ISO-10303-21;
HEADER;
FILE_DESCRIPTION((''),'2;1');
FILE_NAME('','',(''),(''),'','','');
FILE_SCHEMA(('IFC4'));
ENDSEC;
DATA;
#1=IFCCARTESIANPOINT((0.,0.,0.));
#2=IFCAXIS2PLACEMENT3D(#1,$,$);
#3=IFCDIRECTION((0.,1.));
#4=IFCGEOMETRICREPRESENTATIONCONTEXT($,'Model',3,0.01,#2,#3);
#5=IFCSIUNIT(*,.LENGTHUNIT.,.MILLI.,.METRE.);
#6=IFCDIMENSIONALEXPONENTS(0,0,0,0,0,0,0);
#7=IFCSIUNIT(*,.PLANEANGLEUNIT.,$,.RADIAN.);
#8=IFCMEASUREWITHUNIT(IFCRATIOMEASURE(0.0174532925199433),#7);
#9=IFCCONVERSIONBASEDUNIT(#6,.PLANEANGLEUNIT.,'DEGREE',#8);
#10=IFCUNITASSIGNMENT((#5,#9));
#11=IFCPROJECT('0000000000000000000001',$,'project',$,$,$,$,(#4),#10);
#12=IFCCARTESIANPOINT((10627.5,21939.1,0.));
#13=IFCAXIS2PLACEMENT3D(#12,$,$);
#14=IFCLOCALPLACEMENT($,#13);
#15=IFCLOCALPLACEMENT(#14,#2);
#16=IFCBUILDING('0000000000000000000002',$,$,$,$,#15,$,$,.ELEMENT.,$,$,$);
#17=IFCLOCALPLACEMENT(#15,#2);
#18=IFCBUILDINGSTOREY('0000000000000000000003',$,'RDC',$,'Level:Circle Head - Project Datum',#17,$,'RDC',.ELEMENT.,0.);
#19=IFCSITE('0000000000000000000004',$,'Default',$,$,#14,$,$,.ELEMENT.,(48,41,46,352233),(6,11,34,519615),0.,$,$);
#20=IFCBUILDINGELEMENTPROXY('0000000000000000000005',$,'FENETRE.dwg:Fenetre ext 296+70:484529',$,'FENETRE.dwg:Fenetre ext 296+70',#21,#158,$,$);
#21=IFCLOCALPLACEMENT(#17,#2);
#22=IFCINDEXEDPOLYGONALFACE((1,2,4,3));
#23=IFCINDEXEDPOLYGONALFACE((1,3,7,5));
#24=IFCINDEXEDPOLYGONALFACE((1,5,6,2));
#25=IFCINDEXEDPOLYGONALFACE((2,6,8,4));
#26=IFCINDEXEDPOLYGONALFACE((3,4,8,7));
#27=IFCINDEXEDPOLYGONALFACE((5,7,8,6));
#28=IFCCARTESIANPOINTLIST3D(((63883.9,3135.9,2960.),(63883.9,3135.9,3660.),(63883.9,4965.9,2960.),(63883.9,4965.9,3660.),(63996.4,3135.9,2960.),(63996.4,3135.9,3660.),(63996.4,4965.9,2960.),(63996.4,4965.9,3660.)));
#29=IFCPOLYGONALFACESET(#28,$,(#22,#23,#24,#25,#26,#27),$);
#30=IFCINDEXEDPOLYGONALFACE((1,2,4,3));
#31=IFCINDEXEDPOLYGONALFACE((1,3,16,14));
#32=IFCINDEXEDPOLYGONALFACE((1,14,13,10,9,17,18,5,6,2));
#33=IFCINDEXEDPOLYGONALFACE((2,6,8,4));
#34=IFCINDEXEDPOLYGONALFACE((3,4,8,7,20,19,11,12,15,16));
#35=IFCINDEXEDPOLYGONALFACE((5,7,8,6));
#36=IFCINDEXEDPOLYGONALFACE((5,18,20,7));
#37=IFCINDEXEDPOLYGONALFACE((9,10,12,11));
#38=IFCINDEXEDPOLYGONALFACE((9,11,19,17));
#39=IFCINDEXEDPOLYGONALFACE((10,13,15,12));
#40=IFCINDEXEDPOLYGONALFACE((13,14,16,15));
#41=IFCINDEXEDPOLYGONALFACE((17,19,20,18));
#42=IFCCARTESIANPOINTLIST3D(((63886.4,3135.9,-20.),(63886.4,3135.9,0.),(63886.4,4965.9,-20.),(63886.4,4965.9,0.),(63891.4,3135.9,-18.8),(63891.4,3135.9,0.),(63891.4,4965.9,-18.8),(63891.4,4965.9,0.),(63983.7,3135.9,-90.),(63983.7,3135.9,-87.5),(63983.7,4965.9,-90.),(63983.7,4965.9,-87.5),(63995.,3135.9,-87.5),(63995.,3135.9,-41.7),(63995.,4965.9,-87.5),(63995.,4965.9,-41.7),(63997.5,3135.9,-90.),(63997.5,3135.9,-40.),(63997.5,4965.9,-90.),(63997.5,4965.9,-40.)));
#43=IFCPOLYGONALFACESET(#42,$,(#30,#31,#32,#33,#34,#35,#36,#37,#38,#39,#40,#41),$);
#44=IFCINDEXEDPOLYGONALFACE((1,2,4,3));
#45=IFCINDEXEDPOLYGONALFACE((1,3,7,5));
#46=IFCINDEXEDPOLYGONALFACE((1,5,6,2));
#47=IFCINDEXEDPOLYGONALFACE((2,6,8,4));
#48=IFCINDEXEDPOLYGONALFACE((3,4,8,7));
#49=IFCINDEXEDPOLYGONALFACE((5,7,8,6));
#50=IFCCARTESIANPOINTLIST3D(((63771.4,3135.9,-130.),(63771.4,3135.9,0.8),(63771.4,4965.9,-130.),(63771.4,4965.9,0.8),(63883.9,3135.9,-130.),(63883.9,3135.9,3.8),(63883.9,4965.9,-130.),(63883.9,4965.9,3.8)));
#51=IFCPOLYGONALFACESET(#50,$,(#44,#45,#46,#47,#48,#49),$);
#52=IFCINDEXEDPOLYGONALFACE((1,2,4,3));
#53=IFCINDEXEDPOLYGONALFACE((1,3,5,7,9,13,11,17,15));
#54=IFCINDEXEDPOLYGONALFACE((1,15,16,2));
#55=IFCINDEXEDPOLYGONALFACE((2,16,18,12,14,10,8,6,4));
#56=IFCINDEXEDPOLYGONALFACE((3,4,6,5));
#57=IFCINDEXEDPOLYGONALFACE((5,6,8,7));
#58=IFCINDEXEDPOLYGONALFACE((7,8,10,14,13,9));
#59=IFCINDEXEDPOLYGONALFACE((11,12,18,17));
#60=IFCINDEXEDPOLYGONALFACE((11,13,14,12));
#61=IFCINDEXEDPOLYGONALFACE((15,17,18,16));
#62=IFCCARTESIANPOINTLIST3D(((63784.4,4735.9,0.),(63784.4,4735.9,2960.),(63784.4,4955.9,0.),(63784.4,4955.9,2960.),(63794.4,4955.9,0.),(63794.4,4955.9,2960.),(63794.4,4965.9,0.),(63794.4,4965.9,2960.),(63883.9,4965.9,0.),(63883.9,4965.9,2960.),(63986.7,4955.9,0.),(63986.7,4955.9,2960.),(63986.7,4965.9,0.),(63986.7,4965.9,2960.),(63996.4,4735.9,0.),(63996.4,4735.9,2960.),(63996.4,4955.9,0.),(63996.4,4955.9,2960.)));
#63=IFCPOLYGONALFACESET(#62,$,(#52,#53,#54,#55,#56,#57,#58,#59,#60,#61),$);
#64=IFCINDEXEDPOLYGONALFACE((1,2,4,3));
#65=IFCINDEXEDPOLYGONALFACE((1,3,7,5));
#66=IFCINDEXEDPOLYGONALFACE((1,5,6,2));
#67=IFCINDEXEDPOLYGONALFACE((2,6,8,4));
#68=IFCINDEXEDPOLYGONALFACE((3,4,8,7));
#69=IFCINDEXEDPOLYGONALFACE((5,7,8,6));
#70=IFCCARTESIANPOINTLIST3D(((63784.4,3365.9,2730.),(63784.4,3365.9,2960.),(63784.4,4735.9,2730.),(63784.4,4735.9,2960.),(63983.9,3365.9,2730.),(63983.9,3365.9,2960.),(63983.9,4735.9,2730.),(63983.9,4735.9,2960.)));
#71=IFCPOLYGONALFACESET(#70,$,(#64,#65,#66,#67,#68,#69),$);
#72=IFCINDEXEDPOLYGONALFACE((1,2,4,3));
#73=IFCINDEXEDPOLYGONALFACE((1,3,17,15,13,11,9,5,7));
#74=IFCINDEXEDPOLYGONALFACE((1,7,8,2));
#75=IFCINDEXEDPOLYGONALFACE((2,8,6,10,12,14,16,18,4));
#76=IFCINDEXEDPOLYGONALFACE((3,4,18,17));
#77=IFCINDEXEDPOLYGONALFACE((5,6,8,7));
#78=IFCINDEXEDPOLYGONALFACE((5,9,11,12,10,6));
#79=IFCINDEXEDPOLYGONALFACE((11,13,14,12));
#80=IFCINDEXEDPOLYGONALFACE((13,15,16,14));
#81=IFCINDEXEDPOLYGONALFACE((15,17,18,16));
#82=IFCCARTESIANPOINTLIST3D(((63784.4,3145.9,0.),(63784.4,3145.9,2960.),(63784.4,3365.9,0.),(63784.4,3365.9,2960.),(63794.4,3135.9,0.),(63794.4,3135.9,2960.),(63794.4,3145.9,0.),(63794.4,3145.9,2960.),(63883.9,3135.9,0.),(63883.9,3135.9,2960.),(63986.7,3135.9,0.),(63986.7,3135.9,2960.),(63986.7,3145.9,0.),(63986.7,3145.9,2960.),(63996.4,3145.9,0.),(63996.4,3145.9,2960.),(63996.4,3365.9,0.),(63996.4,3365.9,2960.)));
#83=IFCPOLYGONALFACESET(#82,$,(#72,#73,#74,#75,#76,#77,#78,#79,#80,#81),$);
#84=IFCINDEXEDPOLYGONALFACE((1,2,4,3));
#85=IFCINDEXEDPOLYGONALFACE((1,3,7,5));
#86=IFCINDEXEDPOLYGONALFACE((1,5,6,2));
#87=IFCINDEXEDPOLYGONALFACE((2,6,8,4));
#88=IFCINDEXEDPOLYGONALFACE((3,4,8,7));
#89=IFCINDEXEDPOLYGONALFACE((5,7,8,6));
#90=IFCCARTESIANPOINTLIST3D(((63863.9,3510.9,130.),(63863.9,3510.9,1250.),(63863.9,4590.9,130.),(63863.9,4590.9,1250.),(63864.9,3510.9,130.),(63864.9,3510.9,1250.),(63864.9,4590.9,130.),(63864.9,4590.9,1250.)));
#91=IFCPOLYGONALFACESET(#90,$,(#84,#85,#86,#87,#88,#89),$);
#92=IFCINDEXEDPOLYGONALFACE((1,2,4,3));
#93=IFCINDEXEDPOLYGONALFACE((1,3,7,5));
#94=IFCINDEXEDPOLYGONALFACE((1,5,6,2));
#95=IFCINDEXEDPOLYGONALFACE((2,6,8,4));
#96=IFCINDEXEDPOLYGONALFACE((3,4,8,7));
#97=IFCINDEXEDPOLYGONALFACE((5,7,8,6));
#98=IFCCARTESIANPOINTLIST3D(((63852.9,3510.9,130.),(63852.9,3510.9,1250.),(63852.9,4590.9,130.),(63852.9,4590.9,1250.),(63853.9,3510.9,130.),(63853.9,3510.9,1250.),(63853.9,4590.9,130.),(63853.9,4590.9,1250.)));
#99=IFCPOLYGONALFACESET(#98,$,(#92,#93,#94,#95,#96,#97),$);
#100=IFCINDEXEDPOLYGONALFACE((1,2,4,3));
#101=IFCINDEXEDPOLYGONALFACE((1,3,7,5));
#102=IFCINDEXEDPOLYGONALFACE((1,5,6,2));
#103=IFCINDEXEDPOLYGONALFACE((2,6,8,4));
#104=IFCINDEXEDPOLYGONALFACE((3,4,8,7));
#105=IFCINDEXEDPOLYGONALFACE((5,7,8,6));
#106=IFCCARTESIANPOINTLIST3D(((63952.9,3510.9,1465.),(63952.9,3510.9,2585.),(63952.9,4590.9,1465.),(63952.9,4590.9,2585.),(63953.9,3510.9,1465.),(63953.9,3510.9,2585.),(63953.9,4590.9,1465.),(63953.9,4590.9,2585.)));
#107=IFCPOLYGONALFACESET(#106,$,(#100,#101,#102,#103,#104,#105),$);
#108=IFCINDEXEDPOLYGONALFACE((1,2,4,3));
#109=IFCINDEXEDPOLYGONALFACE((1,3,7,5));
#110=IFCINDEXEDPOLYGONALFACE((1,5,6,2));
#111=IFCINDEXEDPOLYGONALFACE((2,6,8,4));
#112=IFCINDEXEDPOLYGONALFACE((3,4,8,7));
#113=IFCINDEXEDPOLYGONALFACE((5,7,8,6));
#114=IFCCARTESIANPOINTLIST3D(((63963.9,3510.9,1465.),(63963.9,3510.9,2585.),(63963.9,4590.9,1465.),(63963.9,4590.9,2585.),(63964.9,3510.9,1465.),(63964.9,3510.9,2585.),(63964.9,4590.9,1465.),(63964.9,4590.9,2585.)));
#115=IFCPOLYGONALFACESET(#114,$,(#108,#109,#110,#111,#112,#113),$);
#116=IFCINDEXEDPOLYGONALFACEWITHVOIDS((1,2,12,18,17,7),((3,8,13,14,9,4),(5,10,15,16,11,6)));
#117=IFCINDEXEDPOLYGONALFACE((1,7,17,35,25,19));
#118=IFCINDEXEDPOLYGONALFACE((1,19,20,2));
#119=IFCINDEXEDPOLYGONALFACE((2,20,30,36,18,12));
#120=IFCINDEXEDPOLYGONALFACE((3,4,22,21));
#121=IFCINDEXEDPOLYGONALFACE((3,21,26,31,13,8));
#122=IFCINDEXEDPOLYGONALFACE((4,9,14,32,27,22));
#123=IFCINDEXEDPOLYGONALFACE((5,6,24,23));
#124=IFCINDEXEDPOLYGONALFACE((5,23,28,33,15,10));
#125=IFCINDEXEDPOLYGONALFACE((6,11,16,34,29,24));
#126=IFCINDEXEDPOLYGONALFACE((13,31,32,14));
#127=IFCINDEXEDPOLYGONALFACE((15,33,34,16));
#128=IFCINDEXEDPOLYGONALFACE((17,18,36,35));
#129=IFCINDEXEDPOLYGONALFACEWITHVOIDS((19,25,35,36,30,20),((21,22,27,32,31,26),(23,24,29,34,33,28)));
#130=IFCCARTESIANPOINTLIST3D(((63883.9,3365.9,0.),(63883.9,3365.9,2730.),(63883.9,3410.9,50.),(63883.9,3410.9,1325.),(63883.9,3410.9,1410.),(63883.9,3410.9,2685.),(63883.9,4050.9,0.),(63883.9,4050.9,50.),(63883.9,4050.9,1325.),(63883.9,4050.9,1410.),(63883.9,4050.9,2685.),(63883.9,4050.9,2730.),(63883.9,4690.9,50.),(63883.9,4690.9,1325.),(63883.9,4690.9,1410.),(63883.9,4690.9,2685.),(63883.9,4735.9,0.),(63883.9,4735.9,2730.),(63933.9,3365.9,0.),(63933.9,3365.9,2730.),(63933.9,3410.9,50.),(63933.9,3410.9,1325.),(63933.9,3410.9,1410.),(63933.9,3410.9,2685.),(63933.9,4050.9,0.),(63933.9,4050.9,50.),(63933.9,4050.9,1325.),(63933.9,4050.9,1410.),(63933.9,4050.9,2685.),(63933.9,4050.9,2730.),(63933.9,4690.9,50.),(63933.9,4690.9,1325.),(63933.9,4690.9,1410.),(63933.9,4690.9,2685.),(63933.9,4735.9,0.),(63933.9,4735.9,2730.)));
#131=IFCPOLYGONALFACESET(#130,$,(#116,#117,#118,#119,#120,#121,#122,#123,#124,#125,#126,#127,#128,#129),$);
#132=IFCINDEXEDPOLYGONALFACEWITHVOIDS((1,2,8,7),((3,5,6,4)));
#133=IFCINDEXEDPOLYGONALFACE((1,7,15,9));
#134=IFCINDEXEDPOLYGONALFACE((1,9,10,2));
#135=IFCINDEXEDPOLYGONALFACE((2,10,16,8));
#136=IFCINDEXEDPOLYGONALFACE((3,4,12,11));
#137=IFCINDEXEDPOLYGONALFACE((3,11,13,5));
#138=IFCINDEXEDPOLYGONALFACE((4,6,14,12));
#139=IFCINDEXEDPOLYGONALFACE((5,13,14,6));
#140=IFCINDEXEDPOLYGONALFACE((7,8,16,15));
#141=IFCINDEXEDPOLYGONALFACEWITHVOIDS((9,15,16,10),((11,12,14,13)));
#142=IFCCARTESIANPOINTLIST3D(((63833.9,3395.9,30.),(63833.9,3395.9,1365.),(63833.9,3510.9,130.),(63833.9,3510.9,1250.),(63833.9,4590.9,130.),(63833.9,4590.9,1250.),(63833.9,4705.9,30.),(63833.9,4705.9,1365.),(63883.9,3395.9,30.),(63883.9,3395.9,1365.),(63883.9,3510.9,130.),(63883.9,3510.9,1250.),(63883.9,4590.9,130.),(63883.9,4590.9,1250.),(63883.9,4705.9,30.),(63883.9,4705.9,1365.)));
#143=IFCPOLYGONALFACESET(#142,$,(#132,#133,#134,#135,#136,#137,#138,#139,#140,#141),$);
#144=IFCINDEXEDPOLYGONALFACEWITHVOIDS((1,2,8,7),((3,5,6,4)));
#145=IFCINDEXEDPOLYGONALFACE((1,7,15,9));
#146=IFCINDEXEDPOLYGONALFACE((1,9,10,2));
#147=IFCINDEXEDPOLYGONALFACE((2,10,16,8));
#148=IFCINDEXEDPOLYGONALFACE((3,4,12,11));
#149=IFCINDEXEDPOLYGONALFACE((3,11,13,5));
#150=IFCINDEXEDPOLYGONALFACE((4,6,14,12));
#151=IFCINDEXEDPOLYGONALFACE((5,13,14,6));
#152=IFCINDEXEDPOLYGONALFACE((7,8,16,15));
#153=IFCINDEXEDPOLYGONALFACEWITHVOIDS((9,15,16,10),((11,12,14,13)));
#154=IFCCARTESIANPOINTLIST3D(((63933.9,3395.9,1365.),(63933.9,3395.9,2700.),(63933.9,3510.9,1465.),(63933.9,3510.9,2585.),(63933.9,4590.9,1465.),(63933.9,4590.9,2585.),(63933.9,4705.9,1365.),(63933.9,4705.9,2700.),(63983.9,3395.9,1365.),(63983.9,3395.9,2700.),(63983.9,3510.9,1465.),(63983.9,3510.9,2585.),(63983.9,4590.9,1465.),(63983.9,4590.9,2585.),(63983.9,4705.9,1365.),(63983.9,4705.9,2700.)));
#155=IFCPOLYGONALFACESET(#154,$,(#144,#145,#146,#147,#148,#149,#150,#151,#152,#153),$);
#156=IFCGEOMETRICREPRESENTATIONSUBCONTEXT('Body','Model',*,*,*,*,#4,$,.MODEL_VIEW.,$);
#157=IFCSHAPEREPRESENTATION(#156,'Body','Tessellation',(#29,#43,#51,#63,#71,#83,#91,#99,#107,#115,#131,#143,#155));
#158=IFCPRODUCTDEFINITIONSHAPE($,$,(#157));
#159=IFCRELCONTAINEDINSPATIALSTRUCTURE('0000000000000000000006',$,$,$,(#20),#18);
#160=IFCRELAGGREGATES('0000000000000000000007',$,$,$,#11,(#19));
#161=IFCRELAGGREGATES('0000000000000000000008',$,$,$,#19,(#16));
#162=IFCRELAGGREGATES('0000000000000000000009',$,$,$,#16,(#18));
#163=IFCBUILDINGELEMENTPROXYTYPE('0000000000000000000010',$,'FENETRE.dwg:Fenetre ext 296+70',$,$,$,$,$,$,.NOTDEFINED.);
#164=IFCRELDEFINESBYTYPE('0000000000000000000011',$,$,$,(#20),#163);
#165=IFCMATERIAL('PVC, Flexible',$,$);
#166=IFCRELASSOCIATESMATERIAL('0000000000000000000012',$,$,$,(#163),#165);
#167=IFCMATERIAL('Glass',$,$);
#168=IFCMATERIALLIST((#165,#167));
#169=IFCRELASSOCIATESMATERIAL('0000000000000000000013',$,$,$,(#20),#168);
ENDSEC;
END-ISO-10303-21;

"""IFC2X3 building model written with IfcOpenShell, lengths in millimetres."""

from ifc_helpers import new_model, entity, si_unit, converted_unit, direction, frame, frame_2d, origin, origin_2d_with_axis, place, context, subcontext, project, spatial, polyline, rectangle, outline, extrude, source, transform, mapped, material, material_list, type_object, type_shapes, element, save


model = new_model("IFC2X3")

# Units and contexts
model_context = context("Model", 3, precision=0.01, world=origin(), true_north=direction((0.0, 1.0)))
body_context = subcontext(model_context, "Body", "Model", "MODEL_VIEW")
ifc_project = project(units=[si_unit("LENGTHUNIT", "METRE", prefix="MILLI"), converted_unit("PLANEANGLEUNIT", "DEGREE", entity("IfcRatioMeasure", 0.0174532925199433), si_unit("PLANEANGLEUNIT", "RADIAN"), dimensions=[0, 0, 0, 0, 0, 0, 0])], contexts=[model_context])

# Site, building, storey
site_placement = place(None, frame((10627.5, 21939.1, 0.0)))
site = spatial("IfcSite", under=ifc_project, at=site_placement, Name="Default", CompositionType="ELEMENT", RefLatitude=(48, 41, 46, 352233), RefLongitude=(6, 11, 34, 519615), RefElevation=0.0)
building_placement = place(site_placement, origin())
building = spatial("IfcBuilding", under=site, at=building_placement, CompositionType="ELEMENT")
storey_placement = place(building_placement, origin())
storey = spatial("IfcBuildingStorey", under=building, at=storey_placement, Name="RDC", ObjectType="Level:Circle Head - Project Datum", LongName="RDC", CompositionType="ELEMENT", Elevation=0.0)

# Building element proxy
ifc_material_1 = material(Name="PVC, Flexible")
ifc_material_2 = material(Name="Glass")
building_element_proxy_type_1 = type_object("IfcBuildingElementProxyType", Name="FENETRE.dwg:Fenetre ext 296+70", PredefinedType="NOTDEFINED", material=ifc_material_1)
shared_shape_1 = source(origin(), body_context, "Body", "SweptSolid", [
    extrude(rectangle(XDim=112.5, YDim=1830.0, at=origin_2d_with_axis()), frame((-10.4, -56.3, 2960.0), z_axis=(0.0, 0.0, 1.0), x_axis=(0.0, 1.0, 0.0)), (0.0, 0.0, 1.0), 700.0),
    extrude(outline(polyline([(27.5, -64.4), (47.5, -64.4), (47.5, -59.4), (28.8, -59.4), (7.5, 46.7), (-42.5, 46.7), (-42.5, 32.9), (-40.0, 32.9), (-40.0, 44.2), (5.8, 44.2), (27.5, -64.4)])), frame((-925.4, -66.9, -47.5), z_axis=(1.0, 0.0, 0.0), x_axis=(0.0, 0.0, 1.0)), (0.0, 0.0, 1.0), 1830.0),
    extrude(outline(polyline([(-54.5, -66.1), (58.0, -66.1), (54.5, 67.6), (-58.0, 64.6), (-54.5, -66.1)])), frame((-925.4, 56.3, -63.8), z_axis=(1.0, 0.0, 0.0), x_axis=(0.0, -0.999645, 0.02665)), (0.0, 0.0, 1.0), 1830.0),
    extrude(outline(polyline([(-97.0, -55.6), (5.9, -55.6), (95.4, -55.6), (95.4, -45.6), (105.4, -45.6), (105.4, 174.4), (-106.6, 174.4), (-106.6, -45.6), (-97.0, -45.6), (-97.0, -55.6)])), frame((849.0, -5.9, 0.0), z_axis=(0.0, 0.0, 1.0), x_axis=(0.0, 1.0, 0.0)), (0.0, 0.0, 1.0), 2960.0),
    extrude(rectangle(XDim=1370.0, YDim=199.5, at=origin_2d_with_axis()), frame((-10.4, -0.3, 2730.0), z_axis=(0.0, 0.0, 1.0), x_axis=(-1.0, 0.0, 0.0)), (0.0, 0.0, 1.0), 230.0),
    extrude(outline(polyline([(-55.6, 97.0), (-55.6, -5.9), (-55.6, -95.4), (-45.6, -95.4), (-45.6, -105.4), (174.4, -105.4), (174.4, 106.6), (-45.6, 106.6), (-45.6, 97.0), (-55.6, 97.0)])), frame((-869.9, -5.9, 0.0), z_axis=(0.0, 0.0, -1.0), x_axis=(1.0, 0.0, 0.0)), (0.0, 0.0, -1.0), 2960.0),
    extrude(rectangle(XDim=1080.0, YDim=1.0, at=origin_2d_with_axis()), frame((-10.4, 19.5, 130.0), z_axis=(0.0, 0.0, 1.0), x_axis=(-1.0, 0.0, 0.0)), (0.0, 0.0, 1.0), 1120.0),
    extrude(rectangle(XDim=1080.0, YDim=1.0, at=origin_2d_with_axis()), frame((-10.4, 30.5, 130.0), z_axis=(0.0, 0.0, 1.0), x_axis=(-1.0, 0.0, 0.0)), (0.0, 0.0, 1.0), 1120.0),
    extrude(rectangle(XDim=1080.0, YDim=1.0, at=frame_2d((0.0, 0.0), x_axis=(1.0, 0.0))), frame((-10.4, -69.5, 1465.0), z_axis=(0.0, 0.0, 1.0), x_axis=(-1.0, 0.0, 0.0)), (0.0, 0.0, 1.0), 1120.0),
    extrude(rectangle(XDim=1080.0, YDim=1.0, at=frame_2d((0.0, 0.0), x_axis=(1.0, 0.0))), frame((-10.4, -80.5, 1465.0), z_axis=(0.0, 0.0, 1.0), x_axis=(-1.0, 0.0, 0.0)), (0.0, 0.0, 1.0), 1120.0),
    extrude(outline(polyline([(-685.0, -1365.0), (0.0, -1365.0), (685.0, -1365.0), (685.0, 1365.0), (0.0, 1365.0), (-685.0, 1365.0), (-685.0, -1365.0)]), holes=[polyline([(-640.0, -1320.0), (-640.0, -45.0), (0.0, -45.0), (640.0, -45.0), (640.0, -1320.0), (0.0, -1320.0), (-640.0, -1320.0)]), polyline([(-640.0, 40.0), (-640.0, 1315.0), (0.0, 1315.0), (640.0, 1315.0), (640.0, 40.0), (0.0, 40.0), (-640.0, 40.0)])]), frame((-10.4, -50.0, 1365.0), z_axis=(0.0, 1.0, 0.0), x_axis=(1.0, 0.0, 0.0)), (0.0, 0.0, 1.0), 50.0),
    extrude(outline(polyline([(-655.0, -667.5), (655.0, -667.5), (655.0, 667.5), (-655.0, 667.5), (-655.0, -667.5)]), holes=[polyline([(-540.0, 552.5), (540.0, 552.5), (540.0, -567.5), (-540.0, -567.5), (-540.0, 552.5)])]), frame((-10.4, 0.0, 697.5), z_axis=(0.0, 1.0, 0.0), x_axis=(-1.0, 0.0, 0.0)), (0.0, 0.0, 1.0), 50.0),
    extrude(outline(polyline([(-655.0, -667.5), (655.0, -667.5), (655.0, 667.5), (-655.0, 667.5), (-655.0, -667.5)]), holes=[polyline([(-540.0, 552.5), (540.0, 552.5), (540.0, -567.5), (-540.0, -567.5), (-540.0, 552.5)])]), frame((-10.4, -100.0, 2032.5), z_axis=(0.0, 1.0, 0.0), x_axis=(-1.0, 0.0, 0.0)), (0.0, 0.0, 1.0), 50.0),
])
type_shapes(building_element_proxy_type_1, [shared_shape_1])
ifc_material_list_1 = material_list([ifc_material_1, ifc_material_2])
proxy_1_placement = place(storey_placement, frame((63883.9, 4061.3, 0.0), z_axis=(0.0, 0.0, 1.0), x_axis=(0.0, 1.0, 0.0)))
element("IfcBuildingElementProxy", 1, at=proxy_1_placement, inside=storey, type_object=building_element_proxy_type_1, material=ifc_material_list_1, Name="FENETRE.dwg:Fenetre ext 296+70:484529", ObjectType="FENETRE.dwg:Fenetre ext 296+70", context=body_context, shape_type="MappedRepresentation", body=[
    mapped(shared_shape_1, transform((0.0, 0.0, 0.0), scale=1.0)),
])

save(model, "model.ifc")
